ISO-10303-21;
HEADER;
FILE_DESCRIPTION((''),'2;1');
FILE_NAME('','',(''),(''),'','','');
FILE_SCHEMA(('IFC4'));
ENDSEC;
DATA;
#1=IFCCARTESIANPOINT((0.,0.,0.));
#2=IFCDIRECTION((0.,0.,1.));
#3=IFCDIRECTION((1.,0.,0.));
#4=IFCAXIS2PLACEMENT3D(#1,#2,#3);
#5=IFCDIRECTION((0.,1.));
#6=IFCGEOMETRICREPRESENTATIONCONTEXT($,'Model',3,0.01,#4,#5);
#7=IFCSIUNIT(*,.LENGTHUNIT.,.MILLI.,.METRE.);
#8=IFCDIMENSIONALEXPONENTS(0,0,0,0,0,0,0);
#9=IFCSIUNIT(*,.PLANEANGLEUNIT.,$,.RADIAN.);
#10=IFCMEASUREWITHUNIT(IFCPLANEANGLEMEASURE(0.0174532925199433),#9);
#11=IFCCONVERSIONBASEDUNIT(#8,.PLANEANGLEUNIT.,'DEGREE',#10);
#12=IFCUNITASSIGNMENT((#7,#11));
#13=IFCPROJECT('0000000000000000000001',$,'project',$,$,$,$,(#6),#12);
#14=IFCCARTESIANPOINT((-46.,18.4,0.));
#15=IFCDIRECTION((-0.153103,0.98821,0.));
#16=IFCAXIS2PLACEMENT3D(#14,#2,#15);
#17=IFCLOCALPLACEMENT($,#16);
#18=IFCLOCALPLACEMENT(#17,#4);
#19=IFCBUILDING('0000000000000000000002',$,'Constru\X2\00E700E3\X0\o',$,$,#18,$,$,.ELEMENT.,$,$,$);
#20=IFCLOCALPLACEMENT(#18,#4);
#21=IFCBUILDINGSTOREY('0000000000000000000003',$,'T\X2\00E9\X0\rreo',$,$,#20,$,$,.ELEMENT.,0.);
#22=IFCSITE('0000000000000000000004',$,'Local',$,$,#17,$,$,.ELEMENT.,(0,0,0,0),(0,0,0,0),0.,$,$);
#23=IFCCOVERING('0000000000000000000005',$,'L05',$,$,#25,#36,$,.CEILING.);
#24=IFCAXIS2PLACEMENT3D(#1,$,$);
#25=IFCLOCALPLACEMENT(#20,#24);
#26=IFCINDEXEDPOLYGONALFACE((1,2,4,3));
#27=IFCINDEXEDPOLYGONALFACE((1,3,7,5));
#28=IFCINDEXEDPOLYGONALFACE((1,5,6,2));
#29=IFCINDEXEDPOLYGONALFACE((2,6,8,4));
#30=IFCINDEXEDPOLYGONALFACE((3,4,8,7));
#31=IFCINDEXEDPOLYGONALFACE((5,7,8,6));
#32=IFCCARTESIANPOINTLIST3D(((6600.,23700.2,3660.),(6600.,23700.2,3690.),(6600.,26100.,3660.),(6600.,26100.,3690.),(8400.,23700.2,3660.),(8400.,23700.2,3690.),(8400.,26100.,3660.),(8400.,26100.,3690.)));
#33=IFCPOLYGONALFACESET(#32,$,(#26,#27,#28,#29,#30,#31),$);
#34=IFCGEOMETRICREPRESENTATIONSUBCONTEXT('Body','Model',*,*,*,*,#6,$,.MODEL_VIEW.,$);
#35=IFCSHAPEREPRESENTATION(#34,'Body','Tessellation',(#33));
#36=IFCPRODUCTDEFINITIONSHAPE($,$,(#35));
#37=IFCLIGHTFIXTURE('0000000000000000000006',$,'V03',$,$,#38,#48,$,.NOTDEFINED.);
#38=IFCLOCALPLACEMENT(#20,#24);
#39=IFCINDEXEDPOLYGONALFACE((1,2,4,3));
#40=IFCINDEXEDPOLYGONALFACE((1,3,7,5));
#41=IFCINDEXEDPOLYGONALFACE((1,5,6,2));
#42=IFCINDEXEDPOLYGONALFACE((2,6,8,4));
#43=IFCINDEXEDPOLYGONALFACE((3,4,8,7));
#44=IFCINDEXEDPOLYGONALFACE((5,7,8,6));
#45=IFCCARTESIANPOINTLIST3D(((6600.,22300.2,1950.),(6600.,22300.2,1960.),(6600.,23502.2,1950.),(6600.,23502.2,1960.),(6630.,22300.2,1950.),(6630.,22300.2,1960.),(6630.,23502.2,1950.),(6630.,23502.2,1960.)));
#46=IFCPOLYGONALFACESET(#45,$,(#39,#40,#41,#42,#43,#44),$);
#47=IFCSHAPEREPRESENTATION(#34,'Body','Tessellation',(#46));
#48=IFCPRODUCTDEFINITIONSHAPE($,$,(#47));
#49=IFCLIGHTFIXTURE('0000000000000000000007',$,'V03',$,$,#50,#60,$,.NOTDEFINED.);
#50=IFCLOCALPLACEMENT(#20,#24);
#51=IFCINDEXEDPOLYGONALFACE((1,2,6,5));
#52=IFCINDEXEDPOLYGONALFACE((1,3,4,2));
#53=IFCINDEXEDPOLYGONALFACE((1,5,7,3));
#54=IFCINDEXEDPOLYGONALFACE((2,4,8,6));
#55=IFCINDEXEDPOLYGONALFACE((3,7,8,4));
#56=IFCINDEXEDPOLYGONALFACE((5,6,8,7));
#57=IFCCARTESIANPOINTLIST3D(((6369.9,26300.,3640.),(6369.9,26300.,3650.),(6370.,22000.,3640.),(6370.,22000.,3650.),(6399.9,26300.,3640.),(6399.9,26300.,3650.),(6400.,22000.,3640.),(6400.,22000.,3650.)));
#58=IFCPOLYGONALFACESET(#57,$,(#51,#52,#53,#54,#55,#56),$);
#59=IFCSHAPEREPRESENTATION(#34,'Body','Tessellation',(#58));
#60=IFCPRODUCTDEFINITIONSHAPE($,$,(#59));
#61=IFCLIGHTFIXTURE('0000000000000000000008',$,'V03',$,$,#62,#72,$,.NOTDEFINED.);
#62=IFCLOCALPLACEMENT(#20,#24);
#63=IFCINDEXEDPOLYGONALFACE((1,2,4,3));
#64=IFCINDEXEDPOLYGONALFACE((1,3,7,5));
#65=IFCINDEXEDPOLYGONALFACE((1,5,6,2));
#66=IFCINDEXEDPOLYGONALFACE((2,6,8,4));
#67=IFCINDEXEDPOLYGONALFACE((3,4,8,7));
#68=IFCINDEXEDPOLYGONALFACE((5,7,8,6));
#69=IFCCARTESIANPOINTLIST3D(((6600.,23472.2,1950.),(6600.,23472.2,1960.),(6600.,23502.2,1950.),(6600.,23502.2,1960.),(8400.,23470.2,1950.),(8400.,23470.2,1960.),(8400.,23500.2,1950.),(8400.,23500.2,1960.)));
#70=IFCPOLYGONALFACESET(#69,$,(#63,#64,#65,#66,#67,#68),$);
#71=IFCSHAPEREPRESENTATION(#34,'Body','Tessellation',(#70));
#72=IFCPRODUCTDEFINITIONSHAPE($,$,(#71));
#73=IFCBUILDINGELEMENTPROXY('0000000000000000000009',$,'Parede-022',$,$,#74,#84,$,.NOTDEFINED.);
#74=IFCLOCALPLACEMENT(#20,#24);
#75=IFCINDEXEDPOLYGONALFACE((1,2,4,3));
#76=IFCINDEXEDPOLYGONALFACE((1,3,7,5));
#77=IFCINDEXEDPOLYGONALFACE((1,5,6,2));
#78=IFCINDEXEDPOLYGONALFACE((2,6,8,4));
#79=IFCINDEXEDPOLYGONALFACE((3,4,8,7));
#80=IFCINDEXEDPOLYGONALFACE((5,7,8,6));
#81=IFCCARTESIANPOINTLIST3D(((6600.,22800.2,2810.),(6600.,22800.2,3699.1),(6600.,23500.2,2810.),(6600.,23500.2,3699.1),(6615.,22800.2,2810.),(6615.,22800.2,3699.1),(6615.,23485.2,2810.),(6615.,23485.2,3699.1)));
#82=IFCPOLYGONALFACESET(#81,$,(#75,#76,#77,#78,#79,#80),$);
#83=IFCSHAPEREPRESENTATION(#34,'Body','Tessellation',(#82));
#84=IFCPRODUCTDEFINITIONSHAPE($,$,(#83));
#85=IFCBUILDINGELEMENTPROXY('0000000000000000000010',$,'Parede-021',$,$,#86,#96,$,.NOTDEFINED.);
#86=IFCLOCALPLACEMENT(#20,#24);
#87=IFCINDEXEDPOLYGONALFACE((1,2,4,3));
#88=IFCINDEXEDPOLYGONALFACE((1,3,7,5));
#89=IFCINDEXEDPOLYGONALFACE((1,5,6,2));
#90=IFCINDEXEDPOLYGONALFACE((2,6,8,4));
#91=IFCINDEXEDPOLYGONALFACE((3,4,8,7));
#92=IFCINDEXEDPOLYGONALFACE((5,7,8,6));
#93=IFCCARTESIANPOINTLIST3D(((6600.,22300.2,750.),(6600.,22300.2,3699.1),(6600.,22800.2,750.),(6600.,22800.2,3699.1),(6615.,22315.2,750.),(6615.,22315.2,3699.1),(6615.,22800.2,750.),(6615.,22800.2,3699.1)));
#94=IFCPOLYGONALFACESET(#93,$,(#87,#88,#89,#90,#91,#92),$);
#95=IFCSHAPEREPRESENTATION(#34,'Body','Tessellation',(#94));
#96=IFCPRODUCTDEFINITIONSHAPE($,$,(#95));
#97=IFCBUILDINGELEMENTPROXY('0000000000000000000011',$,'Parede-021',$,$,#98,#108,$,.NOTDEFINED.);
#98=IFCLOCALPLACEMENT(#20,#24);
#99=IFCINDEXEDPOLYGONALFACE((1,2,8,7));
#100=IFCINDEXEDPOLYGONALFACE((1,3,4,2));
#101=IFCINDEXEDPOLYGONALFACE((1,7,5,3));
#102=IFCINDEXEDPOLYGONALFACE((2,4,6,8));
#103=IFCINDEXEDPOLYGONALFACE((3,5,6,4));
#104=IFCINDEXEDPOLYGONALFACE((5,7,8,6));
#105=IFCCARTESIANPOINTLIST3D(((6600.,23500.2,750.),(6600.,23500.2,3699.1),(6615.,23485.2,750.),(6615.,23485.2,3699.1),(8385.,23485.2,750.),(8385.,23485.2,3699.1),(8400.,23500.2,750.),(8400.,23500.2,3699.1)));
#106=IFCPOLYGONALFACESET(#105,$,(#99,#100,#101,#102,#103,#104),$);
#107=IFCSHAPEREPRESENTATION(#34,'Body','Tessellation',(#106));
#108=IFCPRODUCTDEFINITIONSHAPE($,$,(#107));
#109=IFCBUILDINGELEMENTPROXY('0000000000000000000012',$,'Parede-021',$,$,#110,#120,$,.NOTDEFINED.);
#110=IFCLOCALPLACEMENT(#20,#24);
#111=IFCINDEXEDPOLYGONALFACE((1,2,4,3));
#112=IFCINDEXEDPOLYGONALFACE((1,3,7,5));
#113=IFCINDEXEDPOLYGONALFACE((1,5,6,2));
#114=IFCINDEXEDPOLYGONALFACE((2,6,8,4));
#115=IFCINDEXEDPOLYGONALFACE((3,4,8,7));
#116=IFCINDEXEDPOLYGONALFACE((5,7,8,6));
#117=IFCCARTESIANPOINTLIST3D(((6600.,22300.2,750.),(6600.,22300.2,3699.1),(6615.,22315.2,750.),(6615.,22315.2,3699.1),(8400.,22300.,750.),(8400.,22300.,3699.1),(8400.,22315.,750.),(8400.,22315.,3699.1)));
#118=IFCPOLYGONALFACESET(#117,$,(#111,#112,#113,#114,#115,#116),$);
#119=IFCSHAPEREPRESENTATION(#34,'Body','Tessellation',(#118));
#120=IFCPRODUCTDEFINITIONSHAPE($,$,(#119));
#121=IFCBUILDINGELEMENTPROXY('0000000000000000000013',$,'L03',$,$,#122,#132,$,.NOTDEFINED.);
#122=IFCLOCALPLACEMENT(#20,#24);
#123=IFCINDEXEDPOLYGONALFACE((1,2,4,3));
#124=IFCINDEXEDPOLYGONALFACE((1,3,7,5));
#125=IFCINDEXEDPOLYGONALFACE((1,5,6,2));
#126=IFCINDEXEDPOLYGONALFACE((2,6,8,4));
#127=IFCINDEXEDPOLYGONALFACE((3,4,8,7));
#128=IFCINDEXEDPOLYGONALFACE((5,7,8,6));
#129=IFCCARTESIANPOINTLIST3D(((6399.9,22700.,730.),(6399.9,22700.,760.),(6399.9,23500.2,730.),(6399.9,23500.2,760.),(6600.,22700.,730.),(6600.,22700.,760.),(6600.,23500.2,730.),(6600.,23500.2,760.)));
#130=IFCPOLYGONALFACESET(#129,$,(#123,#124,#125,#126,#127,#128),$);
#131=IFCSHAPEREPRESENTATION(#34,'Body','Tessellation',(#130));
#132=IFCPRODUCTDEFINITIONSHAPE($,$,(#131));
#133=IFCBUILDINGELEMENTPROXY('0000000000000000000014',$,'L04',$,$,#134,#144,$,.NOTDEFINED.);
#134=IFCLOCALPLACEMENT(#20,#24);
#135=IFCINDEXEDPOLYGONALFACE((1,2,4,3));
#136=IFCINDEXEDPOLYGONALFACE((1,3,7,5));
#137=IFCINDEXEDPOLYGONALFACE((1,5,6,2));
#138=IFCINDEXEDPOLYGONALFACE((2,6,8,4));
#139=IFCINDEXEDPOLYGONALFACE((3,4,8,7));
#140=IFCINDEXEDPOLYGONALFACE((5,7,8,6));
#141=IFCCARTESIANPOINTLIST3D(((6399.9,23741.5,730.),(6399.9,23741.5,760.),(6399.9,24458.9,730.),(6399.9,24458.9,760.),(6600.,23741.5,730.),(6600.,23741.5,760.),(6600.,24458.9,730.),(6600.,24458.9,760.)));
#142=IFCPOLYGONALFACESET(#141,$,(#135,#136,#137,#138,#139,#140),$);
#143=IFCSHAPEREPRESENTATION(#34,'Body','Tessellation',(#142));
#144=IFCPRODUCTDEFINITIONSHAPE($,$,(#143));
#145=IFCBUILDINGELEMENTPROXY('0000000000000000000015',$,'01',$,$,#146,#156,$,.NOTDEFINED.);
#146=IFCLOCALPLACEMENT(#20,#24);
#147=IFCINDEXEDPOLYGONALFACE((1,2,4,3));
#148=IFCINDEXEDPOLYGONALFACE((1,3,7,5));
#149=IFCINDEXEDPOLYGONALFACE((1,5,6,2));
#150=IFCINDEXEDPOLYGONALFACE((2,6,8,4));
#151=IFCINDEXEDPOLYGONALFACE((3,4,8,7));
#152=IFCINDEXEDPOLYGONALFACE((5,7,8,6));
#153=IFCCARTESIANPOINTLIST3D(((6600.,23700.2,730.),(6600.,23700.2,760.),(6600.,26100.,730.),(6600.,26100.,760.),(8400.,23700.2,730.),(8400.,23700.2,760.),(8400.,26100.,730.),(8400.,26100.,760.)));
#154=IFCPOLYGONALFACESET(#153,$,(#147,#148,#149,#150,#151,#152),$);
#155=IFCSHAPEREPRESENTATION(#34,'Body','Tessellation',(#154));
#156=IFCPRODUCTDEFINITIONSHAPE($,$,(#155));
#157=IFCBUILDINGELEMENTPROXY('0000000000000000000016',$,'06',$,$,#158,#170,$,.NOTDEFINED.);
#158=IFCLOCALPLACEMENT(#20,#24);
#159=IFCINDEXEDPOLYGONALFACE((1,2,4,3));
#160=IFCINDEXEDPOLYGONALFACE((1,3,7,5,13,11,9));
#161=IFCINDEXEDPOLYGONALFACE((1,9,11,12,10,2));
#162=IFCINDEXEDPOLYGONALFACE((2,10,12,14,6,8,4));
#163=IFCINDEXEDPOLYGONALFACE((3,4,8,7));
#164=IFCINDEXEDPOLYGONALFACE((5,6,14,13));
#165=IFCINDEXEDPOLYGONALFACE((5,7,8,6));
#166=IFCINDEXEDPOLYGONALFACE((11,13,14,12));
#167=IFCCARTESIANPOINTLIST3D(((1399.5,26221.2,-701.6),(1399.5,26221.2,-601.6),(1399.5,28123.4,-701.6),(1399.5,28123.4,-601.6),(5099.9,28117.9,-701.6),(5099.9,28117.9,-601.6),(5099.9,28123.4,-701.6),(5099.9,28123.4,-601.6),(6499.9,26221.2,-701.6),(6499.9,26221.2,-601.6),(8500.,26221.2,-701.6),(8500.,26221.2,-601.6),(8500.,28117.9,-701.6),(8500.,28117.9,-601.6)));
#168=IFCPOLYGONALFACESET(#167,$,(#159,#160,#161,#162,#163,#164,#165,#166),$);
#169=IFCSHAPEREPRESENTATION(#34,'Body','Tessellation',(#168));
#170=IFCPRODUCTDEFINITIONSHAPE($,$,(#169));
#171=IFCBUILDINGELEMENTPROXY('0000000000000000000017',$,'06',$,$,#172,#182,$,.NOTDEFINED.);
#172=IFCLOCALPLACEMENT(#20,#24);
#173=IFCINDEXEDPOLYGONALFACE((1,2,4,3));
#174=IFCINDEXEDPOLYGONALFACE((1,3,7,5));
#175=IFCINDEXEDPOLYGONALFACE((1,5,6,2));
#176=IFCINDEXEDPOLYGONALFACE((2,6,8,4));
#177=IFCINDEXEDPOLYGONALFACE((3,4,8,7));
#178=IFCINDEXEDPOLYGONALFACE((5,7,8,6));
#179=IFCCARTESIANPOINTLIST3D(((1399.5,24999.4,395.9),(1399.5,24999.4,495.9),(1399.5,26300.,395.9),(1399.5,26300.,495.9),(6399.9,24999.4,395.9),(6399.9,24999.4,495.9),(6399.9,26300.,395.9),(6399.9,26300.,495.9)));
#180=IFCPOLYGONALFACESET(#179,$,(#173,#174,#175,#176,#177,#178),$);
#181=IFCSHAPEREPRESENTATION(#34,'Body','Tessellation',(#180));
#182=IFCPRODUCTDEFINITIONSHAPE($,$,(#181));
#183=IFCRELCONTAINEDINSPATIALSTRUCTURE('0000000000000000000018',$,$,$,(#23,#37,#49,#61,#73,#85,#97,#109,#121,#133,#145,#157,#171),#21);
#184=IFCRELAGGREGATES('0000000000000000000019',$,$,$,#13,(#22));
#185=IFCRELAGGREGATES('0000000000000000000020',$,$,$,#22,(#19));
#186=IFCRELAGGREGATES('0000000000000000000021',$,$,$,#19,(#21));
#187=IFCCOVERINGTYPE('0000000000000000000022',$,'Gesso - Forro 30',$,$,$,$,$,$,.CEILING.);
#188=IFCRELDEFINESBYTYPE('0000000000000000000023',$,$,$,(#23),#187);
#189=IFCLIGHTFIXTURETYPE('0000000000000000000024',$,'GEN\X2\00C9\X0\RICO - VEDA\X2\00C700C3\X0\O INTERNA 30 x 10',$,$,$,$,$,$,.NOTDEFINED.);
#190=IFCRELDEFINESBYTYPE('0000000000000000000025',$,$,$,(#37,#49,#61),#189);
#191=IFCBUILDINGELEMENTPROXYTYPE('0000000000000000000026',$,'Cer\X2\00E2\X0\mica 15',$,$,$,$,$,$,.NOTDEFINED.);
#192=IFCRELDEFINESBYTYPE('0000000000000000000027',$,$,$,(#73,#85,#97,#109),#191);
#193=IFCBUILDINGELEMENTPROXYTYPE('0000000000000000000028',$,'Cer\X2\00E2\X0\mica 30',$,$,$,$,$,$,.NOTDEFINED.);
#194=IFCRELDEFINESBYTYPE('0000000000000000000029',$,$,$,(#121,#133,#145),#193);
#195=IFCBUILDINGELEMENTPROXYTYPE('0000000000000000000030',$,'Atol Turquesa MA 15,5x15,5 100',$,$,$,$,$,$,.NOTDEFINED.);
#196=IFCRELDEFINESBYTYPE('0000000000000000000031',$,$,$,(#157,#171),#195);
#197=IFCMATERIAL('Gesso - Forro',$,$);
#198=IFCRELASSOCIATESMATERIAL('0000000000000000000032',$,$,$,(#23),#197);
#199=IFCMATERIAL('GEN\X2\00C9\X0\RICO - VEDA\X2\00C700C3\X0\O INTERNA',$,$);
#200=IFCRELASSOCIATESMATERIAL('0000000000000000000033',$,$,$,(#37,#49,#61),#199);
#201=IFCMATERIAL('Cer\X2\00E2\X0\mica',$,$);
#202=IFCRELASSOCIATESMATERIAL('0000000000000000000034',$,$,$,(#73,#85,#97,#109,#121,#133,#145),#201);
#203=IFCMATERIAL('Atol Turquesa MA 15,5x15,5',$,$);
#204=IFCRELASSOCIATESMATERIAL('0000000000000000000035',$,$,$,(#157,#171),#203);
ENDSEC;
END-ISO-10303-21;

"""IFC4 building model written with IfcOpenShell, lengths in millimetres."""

from ifc_helpers import new_model, entity, si_unit, converted_unit, direction, frame, frame_2d, origin_with_axes, place, context, subcontext, project, spatial, line, indexed_curve, rectangle, outline, extrude, material, type_object, element, save


model = new_model("IFC4")

# Units and contexts
model_context = context("Model", 3, precision=0.01, world=origin_with_axes(), true_north=direction((0.0, 1.0)))
body_context = subcontext(model_context, "Body", "Model", "MODEL_VIEW")
ifc_project = project(units=[si_unit("LENGTHUNIT", "METRE", prefix="MILLI"), converted_unit("PLANEANGLEUNIT", "DEGREE", entity("IfcPlaneAngleMeasure", 0.0174532925199433), si_unit("PLANEANGLEUNIT", "RADIAN"), dimensions=[0, 0, 0, 0, 0, 0, 0])], contexts=[model_context])

# Site, building, storey
site_placement = place(None, frame((-46.0, 18.4, 0.0), z_axis=(0.0, 0.0, 1.0), x_axis=(-0.153103, 0.98821, 0.0)))
site = spatial("IfcSite", under=ifc_project, at=site_placement, Name="Local", CompositionType="ELEMENT", RefLatitude=(0, 0, 0, 0), RefLongitude=(0, 0, 0, 0), RefElevation=0.0)
building_placement = place(site_placement, origin_with_axes())
building = spatial("IfcBuilding", under=site, at=building_placement, Name="Construção", CompositionType="ELEMENT")
storey_placement = place(building_placement, origin_with_axes())
storey = spatial("IfcBuildingStorey", under=building, at=storey_placement, Name="Térreo", CompositionType="ELEMENT", Elevation=0.0)

# Shared definitions
ifc_material_1 = material(Name="Atol Turquesa MA 15,5x15,5")
ifc_material_2 = material(Name="GENÉRICO - VEDAÇÃO INTERNA")

# Covering
ifc_material_3 = material(Name="Gesso - Forro")
covering_type = type_object("IfcCoveringType", Name="Gesso - Forro 30", PredefinedType="CEILING")
covering_1_placement = place(storey_placement, frame((6600.0, 23700.2, 3690.0), z_axis=(0.0, 0.0, 1.0), x_axis=(1.0, 0.0, 0.0)))
element("IfcCovering", 1, at=covering_1_placement, inside=storey, type_object=covering_type, material=ifc_material_3, Name="L05", PredefinedType="CEILING", context=body_context, shape_type="SweptSolid", body=[
    extrude(outline(indexed_curve([(0.0, 0.0), (1800.0, 0.0), (1800.0, 2399.8), (0.0, 2399.8)], segments=[line(1, 2, 3, 4, 1)])), frame((0.0, 0.0, -30.0), z_axis=(0.0, 0.0, 1.0), x_axis=(1.0, 0.0, 0.0)), (0.0, 0.0, 1.0), 30.0),
])

# Light fixtures
light_fixture_type = type_object("IfcLightFixtureType", Name="GENÉRICO - VEDAÇÃO INTERNA 30 x 10", PredefinedType="NOTDEFINED")
light_fixture_1_placement = place(storey_placement, frame((6600.0, 23502.2, 1960.0), z_axis=(0.0, 0.0, 1.0), x_axis=(-1.0, 0.0, 0.0)))
element("IfcLightFixture", 2, at=light_fixture_1_placement, inside=storey, type_object=light_fixture_type, material=ifc_material_2, Name="V03", PredefinedType="NOTDEFINED", context=body_context, shape_type="SweptSolid", body=[
    extrude(rectangle(XDim=10.0, YDim=30.0, at=frame_2d((-5.0, -15.0), x_axis=(1.0, 0.0))), frame((0.0, 0.0, 0.0), z_axis=(0.0, 1.0, 0.0), x_axis=(0.0, 0.0, 1.0)), (0.0, 0.0, 1.0), 1202.0),
])
light_fixture_2_placement = place(storey_placement, frame((6400.0, 22000.0, 3650.0), z_axis=(0.0, 0.0, 1.0), x_axis=(1.0, 0.000013, 0.0)))
element("IfcLightFixture", 3, at=light_fixture_2_placement, inside=storey, type_object=light_fixture_type, material=ifc_material_2, Name="V03", PredefinedType="NOTDEFINED", context=body_context, shape_type="SweptSolid", body=[
    extrude(rectangle(XDim=10.0, YDim=30.0, at=frame_2d((-5.0, -15.0), x_axis=(1.0, 0.0))), frame((0.0, 0.0, 0.0), z_axis=(0.0, 1.0, 0.0), x_axis=(0.0, 0.0, 1.0)), (0.0, 0.0, 1.0), 4300.0),
])
light_fixture_3_placement = place(storey_placement, frame((6600.0, 23472.2, 1960.0), z_axis=(0.0, 0.0, 1.0), x_axis=(-0.001111, -0.999999, 0.0)))
element("IfcLightFixture", 4, at=light_fixture_3_placement, inside=storey, type_object=light_fixture_type, material=ifc_material_2, Name="V03", PredefinedType="NOTDEFINED", context=body_context, shape_type="SweptSolid", body=[
    extrude(rectangle(XDim=10.0, YDim=30.0, at=frame_2d((-5.0, -15.0), x_axis=(1.0, 0.0))), frame((0.0, 0.0, 0.0), z_axis=(0.0, 1.0, 0.0), x_axis=(0.0, 0.0, 1.0)), (0.0, 0.0, 1.0), 1800.0),
])

# Building element proxies
ifc_material_4 = material(Name="Cerâmica")
building_element_proxy_type_1 = type_object("IfcBuildingElementProxyType", Name="Cerâmica 15", PredefinedType="NOTDEFINED")
proxy_1_placement = place(storey_placement, frame((6600.0, 22800.2, 2810.0), z_axis=(0.0, 0.0, 1.0), x_axis=(-0.000014, 1.0, 0.0)))
element("IfcBuildingElementProxy", 5, at=proxy_1_placement, inside=storey, type_object=building_element_proxy_type_1, material=ifc_material_4, Name="Parede-022", PredefinedType="NOTDEFINED", context=body_context, shape_type="SweptSolid", body=[
    extrude(outline(indexed_curve([(0.0, -15.0), (685.0, -15.0), (700.0, 0.0), (0.0, 0.0)], segments=[line(1, 2, 3, 4, 1)])), origin_with_axes(), (0.0, 0.0, 1.0), 889.1),
])
proxy_2_placement = place(storey_placement, frame((6600.0, 22300.2, 750.0), z_axis=(0.0, 0.0, 1.0), x_axis=(-0.000016, 1.0, 0.0)))
element("IfcBuildingElementProxy", 6, at=proxy_2_placement, inside=storey, type_object=building_element_proxy_type_1, material=ifc_material_4, Name="Parede-021", PredefinedType="NOTDEFINED", context=body_context, shape_type="SweptSolid", body=[
    extrude(outline(indexed_curve([(15.0, -15.0), (500.0, -15.0), (500.0, 0.0), (0.0, 0.0)], segments=[line(1, 2, 3, 4, 1)])), origin_with_axes(), (0.0, 0.0, 1.0), 2949.1),
])
proxy_3_placement = place(storey_placement, frame((6600.0, 23500.2, 750.0), z_axis=(0.0, 0.0, 1.0), x_axis=(1.0, 0.0, 0.0)))
element("IfcBuildingElementProxy", 7, at=proxy_3_placement, inside=storey, type_object=building_element_proxy_type_1, material=ifc_material_4, Name="Parede-021", PredefinedType="NOTDEFINED", context=body_context, shape_type="SweptSolid", body=[
    extrude(outline(indexed_curve([(15.0, -15.0), (1785.0, -15.0), (1800.0, 0.0), (0.0, 0.0)], segments=[line(1, 2, 3, 4, 1)])), origin_with_axes(), (0.0, 0.0, 1.0), 2949.1),
])
proxy_4_placement = place(storey_placement, frame((6600.0, 22300.2, 750.0), z_axis=(0.0, 0.0, 1.0), x_axis=(1.0, -0.000083, 0.0)))
element("IfcBuildingElementProxy", 8, at=proxy_4_placement, inside=storey, type_object=building_element_proxy_type_1, material=ifc_material_4, Name="Parede-021", PredefinedType="NOTDEFINED", context=body_context, shape_type="SweptSolid", body=[
    extrude(outline(indexed_curve([(0.0, 0.0), (1800.0, 0.0), (1800.0, 15.0), (15.0, 15.0)], segments=[line(1, 2, 3, 4, 1)])), origin_with_axes(), (0.0, 0.0, 1.0), 2949.1),
])
building_element_proxy_type_2 = type_object("IfcBuildingElementProxyType", Name="Cerâmica 30", PredefinedType="NOTDEFINED")
proxy_5_placement = place(storey_placement, frame((6399.9, 22700.0, 760.0), z_axis=(0.0, 0.0, 1.0), x_axis=(1.0, 0.0, 0.0)))
element("IfcBuildingElementProxy", 9, at=proxy_5_placement, inside=storey, type_object=building_element_proxy_type_2, material=ifc_material_4, Name="L03", PredefinedType="NOTDEFINED", context=body_context, shape_type="SweptSolid", body=[
    extrude(outline(indexed_curve([(0.0, 0.0), (200.0, 0.0), (200.0, 800.2), (0.0, 800.2)], segments=[line(1, 2, 3, 4, 1)])), frame((0.0, 0.0, -30.0), z_axis=(0.0, 0.0, 1.0), x_axis=(1.0, 0.0, 0.0)), (0.0, 0.0, 1.0), 30.0),
])
proxy_6_placement = place(storey_placement, frame((6399.9, 23741.5, 760.0), z_axis=(0.0, 0.0, 1.0), x_axis=(1.0, 0.0, 0.0)))
element("IfcBuildingElementProxy", 10, at=proxy_6_placement, inside=storey, type_object=building_element_proxy_type_2, material=ifc_material_4, Name="L04", PredefinedType="NOTDEFINED", context=body_context, shape_type="SweptSolid", body=[
    extrude(outline(indexed_curve([(0.0, 0.0), (200.0, 0.0), (200.0, 717.3), (0.0, 717.3)], segments=[line(1, 2, 3, 4, 1)])), frame((0.0, 0.0, -30.0), z_axis=(0.0, 0.0, 1.0), x_axis=(1.0, 0.0, 0.0)), (0.0, 0.0, 1.0), 30.0),
])
proxy_7_placement = place(storey_placement, frame((6600.0, 26100.0, 760.0), z_axis=(0.0, 0.0, 1.0), x_axis=(1.0, 0.0, 0.0)))
element("IfcBuildingElementProxy", 11, at=proxy_7_placement, inside=storey, type_object=building_element_proxy_type_2, material=ifc_material_4, Name="01", PredefinedType="NOTDEFINED", context=body_context, shape_type="SweptSolid", body=[
    extrude(outline(indexed_curve([(0.0, 0.0), (0.0, -2399.8), (1800.0, -2399.8), (1800.0, 0.0)], segments=[line(1, 2, 3, 4, 1)])), frame((0.0, 0.0, -30.0), z_axis=(0.0, 0.0, 1.0), x_axis=(1.0, 0.0, 0.0)), (0.0, 0.0, 1.0), 30.0),
])
building_element_proxy_type_3 = type_object("IfcBuildingElementProxyType", Name="Atol Turquesa MA 15,5x15,5 100", PredefinedType="NOTDEFINED")
proxy_8_placement = place(storey_placement, frame((1399.5, 28123.4, -601.6), z_axis=(0.0, 0.0, 1.0), x_axis=(1.0, 0.0, 0.0)))
element("IfcBuildingElementProxy", 12, at=proxy_8_placement, inside=storey, type_object=building_element_proxy_type_3, material=ifc_material_1, Name="06", PredefinedType="NOTDEFINED", context=body_context, shape_type="SweptSolid", body=[
    extrude(outline(indexed_curve([(0.0, 0.0), (0.0, -1902.2), (5100.5, -1902.2), (7100.5, -1902.2), (7100.5, -5.5), (3700.4, -5.5), (3700.4, 0.0)], segments=[line(1, 2, 3, 4, 5, 6, 7, 1)])), frame((0.0, 0.0, -100.0), z_axis=(0.0, 0.0, 1.0), x_axis=(1.0, 0.0, 0.0)), (0.0, 0.0, 1.0), 100.0),
])
proxy_9_placement = place(storey_placement, frame((1399.5, 24999.4, 495.9), z_axis=(0.0, 0.0, 1.0), x_axis=(1.0, 0.0, 0.0)))
element("IfcBuildingElementProxy", 13, at=proxy_9_placement, inside=storey, type_object=building_element_proxy_type_3, material=ifc_material_1, Name="06", PredefinedType="NOTDEFINED", context=body_context, shape_type="SweptSolid", body=[
    extrude(outline(indexed_curve([(0.0, 0.0), (5000.5, 0.0), (5000.5, 1300.6), (0.0, 1300.6)], segments=[line(1, 2, 3, 4, 1)])), frame((0.0, 0.0, -100.0), z_axis=(0.0, 0.0, 1.0), x_axis=(1.0, 0.0, 0.0)), (0.0, 0.0, 1.0), 100.0),
])

save(model, "model.ifc")
